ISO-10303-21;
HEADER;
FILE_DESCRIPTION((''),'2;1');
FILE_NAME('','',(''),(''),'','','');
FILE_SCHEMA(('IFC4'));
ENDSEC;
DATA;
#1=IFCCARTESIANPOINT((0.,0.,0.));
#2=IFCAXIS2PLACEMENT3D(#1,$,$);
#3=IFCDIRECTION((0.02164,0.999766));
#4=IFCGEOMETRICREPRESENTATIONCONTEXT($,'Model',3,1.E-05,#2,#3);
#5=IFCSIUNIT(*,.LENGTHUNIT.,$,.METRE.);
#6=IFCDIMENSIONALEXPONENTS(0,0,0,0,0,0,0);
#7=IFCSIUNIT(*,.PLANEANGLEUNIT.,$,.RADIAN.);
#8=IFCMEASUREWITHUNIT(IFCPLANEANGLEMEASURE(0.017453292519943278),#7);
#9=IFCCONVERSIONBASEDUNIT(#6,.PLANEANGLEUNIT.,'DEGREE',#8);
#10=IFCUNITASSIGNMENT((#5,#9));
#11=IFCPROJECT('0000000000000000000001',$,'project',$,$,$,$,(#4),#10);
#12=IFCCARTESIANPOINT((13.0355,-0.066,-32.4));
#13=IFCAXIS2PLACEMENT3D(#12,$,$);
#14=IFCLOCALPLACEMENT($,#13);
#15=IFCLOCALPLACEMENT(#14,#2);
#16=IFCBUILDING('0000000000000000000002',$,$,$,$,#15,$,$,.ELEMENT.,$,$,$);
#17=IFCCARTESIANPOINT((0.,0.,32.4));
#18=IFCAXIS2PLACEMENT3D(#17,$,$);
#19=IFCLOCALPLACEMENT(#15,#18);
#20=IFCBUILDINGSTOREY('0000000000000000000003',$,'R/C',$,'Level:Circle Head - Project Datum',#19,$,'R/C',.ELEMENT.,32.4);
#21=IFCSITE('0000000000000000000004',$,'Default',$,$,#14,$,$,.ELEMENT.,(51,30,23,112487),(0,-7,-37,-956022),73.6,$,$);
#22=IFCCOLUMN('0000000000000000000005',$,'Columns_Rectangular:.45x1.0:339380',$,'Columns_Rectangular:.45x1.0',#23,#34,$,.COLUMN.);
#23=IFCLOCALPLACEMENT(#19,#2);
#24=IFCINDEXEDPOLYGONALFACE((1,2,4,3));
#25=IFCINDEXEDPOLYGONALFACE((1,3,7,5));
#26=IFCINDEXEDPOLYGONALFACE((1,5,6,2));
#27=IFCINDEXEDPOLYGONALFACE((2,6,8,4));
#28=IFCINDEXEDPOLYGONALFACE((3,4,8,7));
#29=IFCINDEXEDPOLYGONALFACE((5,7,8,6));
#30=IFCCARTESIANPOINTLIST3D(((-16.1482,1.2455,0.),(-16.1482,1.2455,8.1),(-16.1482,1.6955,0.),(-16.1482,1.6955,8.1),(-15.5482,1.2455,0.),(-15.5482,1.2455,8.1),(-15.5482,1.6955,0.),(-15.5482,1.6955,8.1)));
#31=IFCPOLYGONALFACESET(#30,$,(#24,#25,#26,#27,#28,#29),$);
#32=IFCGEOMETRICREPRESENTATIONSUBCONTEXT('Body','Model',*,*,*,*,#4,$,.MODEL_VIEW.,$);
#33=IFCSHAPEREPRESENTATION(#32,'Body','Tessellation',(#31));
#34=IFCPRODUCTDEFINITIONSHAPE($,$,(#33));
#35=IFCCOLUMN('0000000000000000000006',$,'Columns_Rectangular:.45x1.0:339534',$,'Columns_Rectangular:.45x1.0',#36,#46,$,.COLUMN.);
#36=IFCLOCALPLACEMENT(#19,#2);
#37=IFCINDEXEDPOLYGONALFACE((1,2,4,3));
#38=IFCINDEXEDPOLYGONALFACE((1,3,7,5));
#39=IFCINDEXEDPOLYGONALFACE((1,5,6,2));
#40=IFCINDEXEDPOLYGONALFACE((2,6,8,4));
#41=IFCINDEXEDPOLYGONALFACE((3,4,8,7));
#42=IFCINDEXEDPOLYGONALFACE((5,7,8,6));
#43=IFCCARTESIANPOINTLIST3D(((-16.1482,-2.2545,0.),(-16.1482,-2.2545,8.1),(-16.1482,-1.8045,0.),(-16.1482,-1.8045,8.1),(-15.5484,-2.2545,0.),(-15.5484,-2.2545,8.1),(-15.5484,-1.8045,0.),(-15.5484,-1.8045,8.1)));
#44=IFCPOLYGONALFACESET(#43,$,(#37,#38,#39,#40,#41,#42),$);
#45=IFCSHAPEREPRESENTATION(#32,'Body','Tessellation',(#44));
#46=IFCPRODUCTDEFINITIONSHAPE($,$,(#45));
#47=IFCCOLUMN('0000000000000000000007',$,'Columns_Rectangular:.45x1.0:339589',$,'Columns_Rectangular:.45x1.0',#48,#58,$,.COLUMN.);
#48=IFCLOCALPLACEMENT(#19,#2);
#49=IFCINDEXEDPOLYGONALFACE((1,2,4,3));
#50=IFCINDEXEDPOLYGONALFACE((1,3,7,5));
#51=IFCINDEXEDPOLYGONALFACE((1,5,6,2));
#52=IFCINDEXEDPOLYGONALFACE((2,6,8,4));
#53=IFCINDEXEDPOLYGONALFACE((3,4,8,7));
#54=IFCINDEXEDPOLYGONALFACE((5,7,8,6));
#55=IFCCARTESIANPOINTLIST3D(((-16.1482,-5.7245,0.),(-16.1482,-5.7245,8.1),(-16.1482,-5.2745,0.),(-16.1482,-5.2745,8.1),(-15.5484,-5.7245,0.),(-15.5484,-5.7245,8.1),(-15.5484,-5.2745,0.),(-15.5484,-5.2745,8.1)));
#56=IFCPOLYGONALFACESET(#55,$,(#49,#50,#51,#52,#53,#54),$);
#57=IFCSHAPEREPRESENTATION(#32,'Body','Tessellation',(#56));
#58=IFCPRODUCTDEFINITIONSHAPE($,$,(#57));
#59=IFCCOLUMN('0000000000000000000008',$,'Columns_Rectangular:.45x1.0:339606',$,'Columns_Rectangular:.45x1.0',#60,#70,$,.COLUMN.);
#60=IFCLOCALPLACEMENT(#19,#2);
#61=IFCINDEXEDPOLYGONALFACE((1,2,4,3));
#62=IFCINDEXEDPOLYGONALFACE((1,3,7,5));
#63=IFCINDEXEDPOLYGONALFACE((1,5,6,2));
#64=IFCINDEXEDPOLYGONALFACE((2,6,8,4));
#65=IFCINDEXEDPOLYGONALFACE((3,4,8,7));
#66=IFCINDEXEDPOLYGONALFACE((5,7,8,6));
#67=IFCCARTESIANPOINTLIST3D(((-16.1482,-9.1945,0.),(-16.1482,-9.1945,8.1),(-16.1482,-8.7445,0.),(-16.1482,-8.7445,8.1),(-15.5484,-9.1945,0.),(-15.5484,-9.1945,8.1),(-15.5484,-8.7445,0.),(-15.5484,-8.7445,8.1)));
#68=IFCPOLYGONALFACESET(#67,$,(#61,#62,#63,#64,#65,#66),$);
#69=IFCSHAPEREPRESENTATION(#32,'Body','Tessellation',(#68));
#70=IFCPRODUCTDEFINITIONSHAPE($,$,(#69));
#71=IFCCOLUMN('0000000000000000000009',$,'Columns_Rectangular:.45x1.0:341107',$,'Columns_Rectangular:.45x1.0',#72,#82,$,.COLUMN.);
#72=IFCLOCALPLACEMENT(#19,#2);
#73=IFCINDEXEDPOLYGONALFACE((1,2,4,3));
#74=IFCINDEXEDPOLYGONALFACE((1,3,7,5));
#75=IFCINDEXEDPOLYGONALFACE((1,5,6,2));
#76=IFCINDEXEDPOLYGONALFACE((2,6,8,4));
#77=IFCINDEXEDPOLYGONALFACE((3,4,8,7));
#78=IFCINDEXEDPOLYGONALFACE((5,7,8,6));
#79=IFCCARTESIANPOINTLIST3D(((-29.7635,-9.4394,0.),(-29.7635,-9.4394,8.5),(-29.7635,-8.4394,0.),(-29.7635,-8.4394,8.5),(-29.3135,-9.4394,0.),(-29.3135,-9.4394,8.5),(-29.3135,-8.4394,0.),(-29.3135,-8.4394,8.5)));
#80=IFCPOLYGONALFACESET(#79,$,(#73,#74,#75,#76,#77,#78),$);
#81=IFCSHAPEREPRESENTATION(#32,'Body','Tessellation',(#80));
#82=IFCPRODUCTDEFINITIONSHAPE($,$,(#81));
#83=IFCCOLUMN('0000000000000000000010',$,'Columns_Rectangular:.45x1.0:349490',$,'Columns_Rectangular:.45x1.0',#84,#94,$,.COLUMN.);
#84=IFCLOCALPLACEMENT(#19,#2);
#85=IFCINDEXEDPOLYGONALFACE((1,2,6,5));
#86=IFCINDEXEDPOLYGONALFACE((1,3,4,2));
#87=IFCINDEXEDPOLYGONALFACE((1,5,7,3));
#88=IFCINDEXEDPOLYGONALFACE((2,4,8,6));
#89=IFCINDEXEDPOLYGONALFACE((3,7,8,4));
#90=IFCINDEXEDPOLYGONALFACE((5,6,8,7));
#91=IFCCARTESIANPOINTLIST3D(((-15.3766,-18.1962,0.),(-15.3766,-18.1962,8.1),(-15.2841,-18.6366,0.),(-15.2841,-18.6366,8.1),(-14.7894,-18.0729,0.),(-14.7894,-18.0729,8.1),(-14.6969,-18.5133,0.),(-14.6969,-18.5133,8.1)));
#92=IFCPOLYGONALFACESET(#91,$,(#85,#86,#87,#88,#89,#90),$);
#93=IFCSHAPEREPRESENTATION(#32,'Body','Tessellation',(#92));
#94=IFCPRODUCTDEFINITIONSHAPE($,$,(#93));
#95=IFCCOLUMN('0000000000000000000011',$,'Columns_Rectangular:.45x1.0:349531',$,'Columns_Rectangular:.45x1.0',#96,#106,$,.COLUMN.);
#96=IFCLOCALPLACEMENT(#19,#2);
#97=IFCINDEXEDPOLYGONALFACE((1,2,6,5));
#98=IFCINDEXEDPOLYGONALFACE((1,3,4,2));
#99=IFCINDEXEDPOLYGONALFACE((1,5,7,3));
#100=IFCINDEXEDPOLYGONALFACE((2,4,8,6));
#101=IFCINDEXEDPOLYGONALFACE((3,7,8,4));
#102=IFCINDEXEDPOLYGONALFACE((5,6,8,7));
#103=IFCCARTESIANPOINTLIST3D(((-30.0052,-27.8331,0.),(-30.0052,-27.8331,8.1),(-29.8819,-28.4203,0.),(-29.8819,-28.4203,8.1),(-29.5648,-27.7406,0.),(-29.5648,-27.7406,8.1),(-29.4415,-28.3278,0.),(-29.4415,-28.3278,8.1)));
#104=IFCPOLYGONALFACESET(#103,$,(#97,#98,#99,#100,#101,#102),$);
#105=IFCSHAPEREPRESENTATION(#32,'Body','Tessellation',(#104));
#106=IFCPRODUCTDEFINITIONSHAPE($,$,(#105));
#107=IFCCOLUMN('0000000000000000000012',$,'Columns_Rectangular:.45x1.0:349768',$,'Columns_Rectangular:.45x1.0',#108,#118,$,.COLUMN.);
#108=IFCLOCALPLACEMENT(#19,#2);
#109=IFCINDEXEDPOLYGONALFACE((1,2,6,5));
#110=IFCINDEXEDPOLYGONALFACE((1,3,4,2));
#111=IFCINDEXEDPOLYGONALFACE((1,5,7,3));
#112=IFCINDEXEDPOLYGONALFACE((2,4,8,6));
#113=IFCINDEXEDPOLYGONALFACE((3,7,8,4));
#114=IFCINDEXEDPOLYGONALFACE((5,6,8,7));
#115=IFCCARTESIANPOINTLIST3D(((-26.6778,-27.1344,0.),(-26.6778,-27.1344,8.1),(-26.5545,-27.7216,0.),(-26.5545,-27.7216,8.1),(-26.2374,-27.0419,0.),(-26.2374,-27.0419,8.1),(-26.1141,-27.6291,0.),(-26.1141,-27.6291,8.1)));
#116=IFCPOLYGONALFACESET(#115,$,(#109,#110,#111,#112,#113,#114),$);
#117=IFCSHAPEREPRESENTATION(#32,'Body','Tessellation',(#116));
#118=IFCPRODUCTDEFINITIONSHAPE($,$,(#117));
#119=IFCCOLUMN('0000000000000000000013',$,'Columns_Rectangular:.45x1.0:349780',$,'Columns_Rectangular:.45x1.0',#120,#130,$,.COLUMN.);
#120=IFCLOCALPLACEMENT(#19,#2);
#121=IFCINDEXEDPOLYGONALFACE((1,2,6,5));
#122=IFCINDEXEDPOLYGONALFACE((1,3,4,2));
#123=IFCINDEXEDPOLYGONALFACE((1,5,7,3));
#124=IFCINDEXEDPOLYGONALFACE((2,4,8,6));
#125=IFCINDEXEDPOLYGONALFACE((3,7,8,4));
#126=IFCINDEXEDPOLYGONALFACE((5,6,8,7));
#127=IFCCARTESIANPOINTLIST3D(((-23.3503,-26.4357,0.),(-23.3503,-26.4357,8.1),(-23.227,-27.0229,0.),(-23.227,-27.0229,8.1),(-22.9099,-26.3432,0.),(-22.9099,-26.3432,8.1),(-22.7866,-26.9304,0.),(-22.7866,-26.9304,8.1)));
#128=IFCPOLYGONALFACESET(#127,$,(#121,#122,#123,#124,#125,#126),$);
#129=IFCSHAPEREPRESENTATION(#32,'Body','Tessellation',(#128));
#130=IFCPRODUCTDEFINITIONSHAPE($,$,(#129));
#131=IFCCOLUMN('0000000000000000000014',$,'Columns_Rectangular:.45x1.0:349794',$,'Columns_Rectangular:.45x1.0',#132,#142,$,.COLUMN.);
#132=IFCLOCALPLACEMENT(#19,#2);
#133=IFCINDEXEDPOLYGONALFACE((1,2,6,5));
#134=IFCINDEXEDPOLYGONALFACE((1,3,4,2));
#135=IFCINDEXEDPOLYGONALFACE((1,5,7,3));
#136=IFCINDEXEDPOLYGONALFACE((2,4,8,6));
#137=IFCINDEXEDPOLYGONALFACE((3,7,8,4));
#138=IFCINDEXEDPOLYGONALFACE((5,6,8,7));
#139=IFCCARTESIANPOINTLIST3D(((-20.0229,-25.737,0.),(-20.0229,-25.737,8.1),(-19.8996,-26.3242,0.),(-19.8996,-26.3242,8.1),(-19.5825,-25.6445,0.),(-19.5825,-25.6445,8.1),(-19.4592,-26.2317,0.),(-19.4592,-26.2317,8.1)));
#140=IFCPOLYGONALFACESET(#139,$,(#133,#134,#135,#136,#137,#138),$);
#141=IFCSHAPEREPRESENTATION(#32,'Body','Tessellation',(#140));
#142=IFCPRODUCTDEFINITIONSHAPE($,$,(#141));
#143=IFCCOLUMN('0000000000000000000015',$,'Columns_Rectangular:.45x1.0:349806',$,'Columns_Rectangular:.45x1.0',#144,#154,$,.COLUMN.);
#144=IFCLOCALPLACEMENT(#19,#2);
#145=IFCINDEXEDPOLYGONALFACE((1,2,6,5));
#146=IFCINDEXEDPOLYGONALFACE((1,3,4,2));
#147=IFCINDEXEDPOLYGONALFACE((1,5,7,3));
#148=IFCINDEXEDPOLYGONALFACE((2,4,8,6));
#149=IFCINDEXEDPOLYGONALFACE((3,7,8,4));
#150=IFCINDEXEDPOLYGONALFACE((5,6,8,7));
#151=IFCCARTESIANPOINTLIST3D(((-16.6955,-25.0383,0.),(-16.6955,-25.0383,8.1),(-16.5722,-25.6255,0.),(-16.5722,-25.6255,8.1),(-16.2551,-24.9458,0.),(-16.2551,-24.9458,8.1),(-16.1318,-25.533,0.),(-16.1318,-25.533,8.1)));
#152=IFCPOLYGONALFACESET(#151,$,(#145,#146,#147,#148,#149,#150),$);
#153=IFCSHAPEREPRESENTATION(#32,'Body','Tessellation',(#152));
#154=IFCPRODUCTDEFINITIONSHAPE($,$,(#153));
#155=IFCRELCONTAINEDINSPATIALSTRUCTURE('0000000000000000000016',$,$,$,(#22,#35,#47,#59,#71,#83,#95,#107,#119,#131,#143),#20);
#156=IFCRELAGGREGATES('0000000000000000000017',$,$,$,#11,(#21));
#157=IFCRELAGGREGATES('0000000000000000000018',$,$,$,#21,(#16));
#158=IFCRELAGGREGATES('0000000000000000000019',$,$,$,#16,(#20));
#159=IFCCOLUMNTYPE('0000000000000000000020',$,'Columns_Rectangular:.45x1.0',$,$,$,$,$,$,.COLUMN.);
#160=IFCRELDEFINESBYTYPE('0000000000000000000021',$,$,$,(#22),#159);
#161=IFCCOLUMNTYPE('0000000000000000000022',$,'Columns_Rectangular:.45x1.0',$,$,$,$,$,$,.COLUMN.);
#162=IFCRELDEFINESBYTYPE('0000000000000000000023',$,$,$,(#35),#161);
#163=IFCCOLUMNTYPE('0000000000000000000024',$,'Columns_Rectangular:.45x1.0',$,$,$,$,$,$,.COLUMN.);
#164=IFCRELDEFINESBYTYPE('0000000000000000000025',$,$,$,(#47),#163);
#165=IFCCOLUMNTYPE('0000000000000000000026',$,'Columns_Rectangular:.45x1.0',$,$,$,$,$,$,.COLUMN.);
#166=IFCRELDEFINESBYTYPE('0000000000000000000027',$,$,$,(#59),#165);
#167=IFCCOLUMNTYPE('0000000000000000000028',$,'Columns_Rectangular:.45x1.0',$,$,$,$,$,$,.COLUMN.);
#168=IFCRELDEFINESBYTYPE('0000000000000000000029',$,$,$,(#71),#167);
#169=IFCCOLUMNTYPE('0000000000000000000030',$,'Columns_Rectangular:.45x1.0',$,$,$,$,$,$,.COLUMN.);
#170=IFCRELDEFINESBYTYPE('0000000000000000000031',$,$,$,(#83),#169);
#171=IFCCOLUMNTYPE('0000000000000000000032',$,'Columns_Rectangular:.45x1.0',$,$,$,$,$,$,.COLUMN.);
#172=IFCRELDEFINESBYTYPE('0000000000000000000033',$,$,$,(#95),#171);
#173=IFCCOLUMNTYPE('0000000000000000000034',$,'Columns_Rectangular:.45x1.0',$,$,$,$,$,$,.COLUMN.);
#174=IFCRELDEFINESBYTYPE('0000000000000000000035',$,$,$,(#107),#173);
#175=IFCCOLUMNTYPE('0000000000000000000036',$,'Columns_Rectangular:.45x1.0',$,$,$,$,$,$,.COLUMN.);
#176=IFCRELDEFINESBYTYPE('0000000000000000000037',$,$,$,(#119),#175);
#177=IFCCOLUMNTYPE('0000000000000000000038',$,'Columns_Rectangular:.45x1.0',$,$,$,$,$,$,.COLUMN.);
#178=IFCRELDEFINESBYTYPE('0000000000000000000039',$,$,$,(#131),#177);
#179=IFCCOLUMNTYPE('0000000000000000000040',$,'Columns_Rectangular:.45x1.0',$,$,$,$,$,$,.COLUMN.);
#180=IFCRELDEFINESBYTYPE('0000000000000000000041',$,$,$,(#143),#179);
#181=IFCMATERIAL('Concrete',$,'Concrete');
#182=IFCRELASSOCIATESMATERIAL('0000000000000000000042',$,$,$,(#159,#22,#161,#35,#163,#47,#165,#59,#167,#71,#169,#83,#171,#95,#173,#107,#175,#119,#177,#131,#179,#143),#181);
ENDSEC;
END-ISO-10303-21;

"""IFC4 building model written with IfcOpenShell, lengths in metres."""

from ifc_helpers import new_model, entity, si_unit, converted_unit, direction, frame, origin, place, context, subcontext, project, spatial, indexed_curve, outline, extrude, source, transform, mapped, material, type_object, type_shapes, element, save


model = new_model("IFC4")

# Units and contexts
model_context = context("Model", 3, precision=1e-05, world=origin(), true_north=direction((0.02164, 0.999766)))
body_context = subcontext(model_context, "Body", "Model", "MODEL_VIEW")
ifc_project = project(units=[si_unit("LENGTHUNIT", "METRE"), converted_unit("PLANEANGLEUNIT", "DEGREE", entity("IfcPlaneAngleMeasure", 0.017453292519943278), si_unit("PLANEANGLEUNIT", "RADIAN"), dimensions=[0, 0, 0, 0, 0, 0, 0])], contexts=[model_context])

# Site, building, storey
site_placement = place(None, frame((13.0355, -0.066, -32.4)))
site = spatial("IfcSite", under=ifc_project, at=site_placement, Name="Default", CompositionType="ELEMENT", RefLatitude=(51, 30, 23, 112487), RefLongitude=(0, -7, -37, -956022), RefElevation=73.6)
building_placement = place(site_placement, origin())
building = spatial("IfcBuilding", under=site, at=building_placement, CompositionType="ELEMENT")
storey_placement = place(building_placement, frame((0.0, 0.0, 32.4)))
storey = spatial("IfcBuildingStorey", under=building, at=storey_placement, Name="R/C", ObjectType="Level:Circle Head - Project Datum", LongName="R/C", CompositionType="ELEMENT", Elevation=32.4)

# Columns
ifc_material = material(Name="Concrete", Category="Concrete")
column_type_1 = type_object("IfcColumnType", Name="Columns_Rectangular:.45x1.0", PredefinedType="COLUMN", material=ifc_material)
shared_shape_1 = source(origin(), body_context, "Body", "SweptSolid", [
    extrude(outline(indexed_curve([(-0.3, -0.225), (0.3, -0.225), (0.3, 0.225), (-0.3, 0.225), (-0.3, -0.225)], self_intersect=False)), frame((-15.8482, 1.4705, 32.4), z_axis=(0.0, 0.0, 1.0), x_axis=(-1.0, 0.0, 0.0)), (0.0, 0.0, 1.0), 8.1),
])
type_shapes(column_type_1, [shared_shape_1])
column_1_placement = place(storey_placement, frame((0.0, 0.0, -32.4)))
element("IfcColumn", 1, at=column_1_placement, inside=storey, type_object=column_type_1, material=ifc_material, Name="Columns_Rectangular:.45x1.0:339380", ObjectType="Columns_Rectangular:.45x1.0", PredefinedType="COLUMN", context=body_context, shape_type="MappedRepresentation", body=[
    mapped(shared_shape_1, transform((0.0, 0.0, 0.0), scale=1.0)),
])
column_type_2 = type_object("IfcColumnType", Name="Columns_Rectangular:.45x1.0", PredefinedType="COLUMN", material=ifc_material)
shared_shape_2 = source(origin(), body_context, "Body", "SweptSolid", [
    extrude(outline(indexed_curve([(-0.2999, -0.225), (0.2999, -0.225), (0.2999, 0.225), (-0.2999, 0.225), (-0.2999, -0.225)], self_intersect=False)), frame((-15.8483, -2.0295, 32.4), z_axis=(0.0, 0.0, 1.0), x_axis=(-1.0, 0.0, 0.0)), (0.0, 0.0, 1.0), 8.1),
])
type_shapes(column_type_2, [shared_shape_2])
column_2_placement = place(storey_placement, frame((0.0, 0.0, -32.4)))
element("IfcColumn", 2, at=column_2_placement, inside=storey, type_object=column_type_2, material=ifc_material, Name="Columns_Rectangular:.45x1.0:339534", ObjectType="Columns_Rectangular:.45x1.0", PredefinedType="COLUMN", context=body_context, shape_type="MappedRepresentation", body=[
    mapped(shared_shape_2, transform((0.0, 0.0, 0.0), scale=1.0)),
])
column_type_3 = type_object("IfcColumnType", Name="Columns_Rectangular:.45x1.0", PredefinedType="COLUMN", material=ifc_material)
shared_shape_3 = source(origin(), body_context, "Body", "SweptSolid", [
    extrude(outline(indexed_curve([(-0.2999, -0.225), (0.2999, -0.225), (0.2999, 0.225), (-0.2999, 0.225), (-0.2999, -0.225)], self_intersect=False)), frame((-15.8483, -5.4995, 32.4), z_axis=(0.0, 0.0, 1.0), x_axis=(-1.0, 0.0, 0.0)), (0.0, 0.0, 1.0), 8.1),
])
type_shapes(column_type_3, [shared_shape_3])
column_3_placement = place(storey_placement, frame((0.0, 0.0, -32.4)))
element("IfcColumn", 3, at=column_3_placement, inside=storey, type_object=column_type_3, material=ifc_material, Name="Columns_Rectangular:.45x1.0:339589", ObjectType="Columns_Rectangular:.45x1.0", PredefinedType="COLUMN", context=body_context, shape_type="MappedRepresentation", body=[
    mapped(shared_shape_3, transform((0.0, 0.0, 0.0), scale=1.0)),
])
column_type_4 = type_object("IfcColumnType", Name="Columns_Rectangular:.45x1.0", PredefinedType="COLUMN", material=ifc_material)
shared_shape_4 = source(origin(), body_context, "Body", "SweptSolid", [
    extrude(outline(indexed_curve([(-0.2999, -0.225), (0.2999, -0.225), (0.2999, 0.225), (-0.2999, 0.225), (-0.2999, -0.225)], self_intersect=False)), frame((-15.8483, -8.9695, 32.4), z_axis=(0.0, 0.0, 1.0), x_axis=(-1.0, 0.0, 0.0)), (0.0, 0.0, 1.0), 8.1),
])
type_shapes(column_type_4, [shared_shape_4])
column_4_placement = place(storey_placement, frame((0.0, 0.0, -32.4)))
element("IfcColumn", 4, at=column_4_placement, inside=storey, type_object=column_type_4, material=ifc_material, Name="Columns_Rectangular:.45x1.0:339606", ObjectType="Columns_Rectangular:.45x1.0", PredefinedType="COLUMN", context=body_context, shape_type="MappedRepresentation", body=[
    mapped(shared_shape_4, transform((0.0, 0.0, 0.0), scale=1.0)),
])
column_type_5 = type_object("IfcColumnType", Name="Columns_Rectangular:.45x1.0", PredefinedType="COLUMN", material=ifc_material)
shared_shape_5 = source(origin(), body_context, "Body", "SweptSolid", [
    extrude(outline(indexed_curve([(-0.5, -0.225), (0.5, -0.225), (0.5, 0.225), (-0.5, 0.225), (-0.5, -0.225)], self_intersect=False)), frame((-29.5385, -8.9394, 32.4), z_axis=(0.0, 0.0, 1.0), x_axis=(0.0, 1.0, 0.0)), (0.0, 0.0, 1.0), 8.5),
])
type_shapes(column_type_5, [shared_shape_5])
column_5_placement = place(storey_placement, frame((0.0, 0.0, -32.4)))
element("IfcColumn", 5, at=column_5_placement, inside=storey, type_object=column_type_5, material=ifc_material, Name="Columns_Rectangular:.45x1.0:341107", ObjectType="Columns_Rectangular:.45x1.0", PredefinedType="COLUMN", context=body_context, shape_type="MappedRepresentation", body=[
    mapped(shared_shape_5, transform((0.0, 0.0, 0.0), scale=1.0)),
])
column_type_6 = type_object("IfcColumnType", Name="Columns_Rectangular:.45x1.0", PredefinedType="COLUMN", material=ifc_material)
shared_shape_6 = source(origin(), body_context, "Body", "SweptSolid", [
    extrude(outline(indexed_curve([(-0.3, -0.225), (0.3, -0.225), (0.3, 0.225), (-0.3, 0.225), (-0.3, -0.225)], self_intersect=False)), frame((-15.0367, -18.3548, 32.4), z_axis=(0.0, 0.0, 1.0), x_axis=(0.978657, 0.2055, 0.0)), (0.0, 0.0, 1.0), 8.1),
])
type_shapes(column_type_6, [shared_shape_6])
column_6_placement = place(storey_placement, frame((0.0, 0.0, -32.4)))
element("IfcColumn", 6, at=column_6_placement, inside=storey, type_object=column_type_6, material=ifc_material, Name="Columns_Rectangular:.45x1.0:349490", ObjectType="Columns_Rectangular:.45x1.0", PredefinedType="COLUMN", context=body_context, shape_type="MappedRepresentation", body=[
    mapped(shared_shape_6, transform((0.0, 0.0, 0.0), scale=1.0)),
])
column_type_7 = type_object("IfcColumnType", Name="Columns_Rectangular:.45x1.0", PredefinedType="COLUMN", material=ifc_material)
shared_shape_7 = source(origin(), body_context, "Body", "SweptSolid", [
    extrude(outline(indexed_curve([(-0.3, -0.225), (0.3, -0.225), (0.3, 0.225), (-0.3, 0.225), (-0.3, -0.225)], self_intersect=False)), frame((-29.7234, -28.0804, 32.4), z_axis=(0.0, 0.0, 1.0), x_axis=(0.2055, -0.978657, 0.0)), (0.0, 0.0, 1.0), 8.1),
])
type_shapes(column_type_7, [shared_shape_7])
column_7_placement = place(storey_placement, frame((0.0, 0.0, -32.4)))
element("IfcColumn", 7, at=column_7_placement, inside=storey, type_object=column_type_7, material=ifc_material, Name="Columns_Rectangular:.45x1.0:349531", ObjectType="Columns_Rectangular:.45x1.0", PredefinedType="COLUMN", context=body_context, shape_type="MappedRepresentation", body=[
    mapped(shared_shape_7, transform((0.0, 0.0, 0.0), scale=1.0)),
])
column_type_8 = type_object("IfcColumnType", Name="Columns_Rectangular:.45x1.0", PredefinedType="COLUMN", material=ifc_material)
shared_shape_8 = source(origin(), body_context, "Body", "SweptSolid", [
    extrude(outline(indexed_curve([(-0.3, -0.225), (0.3, -0.225), (0.3, 0.225), (-0.3, 0.225), (-0.3, -0.225)], self_intersect=False)), frame((-26.3959, -27.3817, 32.4), z_axis=(0.0, 0.0, 1.0), x_axis=(0.2055, -0.978657, 0.0)), (0.0, 0.0, 1.0), 8.1),
])
type_shapes(column_type_8, [shared_shape_8])
column_8_placement = place(storey_placement, frame((0.0, 0.0, -32.4)))
element("IfcColumn", 8, at=column_8_placement, inside=storey, type_object=column_type_8, material=ifc_material, Name="Columns_Rectangular:.45x1.0:349768", ObjectType="Columns_Rectangular:.45x1.0", PredefinedType="COLUMN", context=body_context, shape_type="MappedRepresentation", body=[
    mapped(shared_shape_8, transform((0.0, 0.0, 0.0), scale=1.0)),
])
column_type_9 = type_object("IfcColumnType", Name="Columns_Rectangular:.45x1.0", PredefinedType="COLUMN", material=ifc_material)
shared_shape_9 = source(origin(), body_context, "Body", "SweptSolid", [
    extrude(outline(indexed_curve([(-0.3, -0.225), (0.3, -0.225), (0.3, 0.225), (-0.3, 0.225), (-0.3, -0.225)], self_intersect=False)), frame((-23.0685, -26.6831, 32.4), z_axis=(0.0, 0.0, 1.0), x_axis=(0.2055, -0.978657, 0.0)), (0.0, 0.0, 1.0), 8.1),
])
type_shapes(column_type_9, [shared_shape_9])
column_9_placement = place(storey_placement, frame((0.0, 0.0, -32.4)))
element("IfcColumn", 9, at=column_9_placement, inside=storey, type_object=column_type_9, material=ifc_material, Name="Columns_Rectangular:.45x1.0:349780", ObjectType="Columns_Rectangular:.45x1.0", PredefinedType="COLUMN", context=body_context, shape_type="MappedRepresentation", body=[
    mapped(shared_shape_9, transform((0.0, 0.0, 0.0), scale=1.0)),
])
column_type_10 = type_object("IfcColumnType", Name="Columns_Rectangular:.45x1.0", PredefinedType="COLUMN", material=ifc_material)
shared_shape_10 = source(origin(), body_context, "Body", "SweptSolid", [
    extrude(outline(indexed_curve([(-0.3, -0.225), (0.3, -0.225), (0.3, 0.225), (-0.3, 0.225), (-0.3, -0.225)], self_intersect=False)), frame((-19.741, -25.9844, 32.4), z_axis=(0.0, 0.0, 1.0), x_axis=(0.2055, -0.978657, 0.0)), (0.0, 0.0, 1.0), 8.1),
])
type_shapes(column_type_10, [shared_shape_10])
column_10_placement = place(storey_placement, frame((0.0, 0.0, -32.4)))
element("IfcColumn", 10, at=column_10_placement, inside=storey, type_object=column_type_10, material=ifc_material, Name="Columns_Rectangular:.45x1.0:349794", ObjectType="Columns_Rectangular:.45x1.0", PredefinedType="COLUMN", context=body_context, shape_type="MappedRepresentation", body=[
    mapped(shared_shape_10, transform((0.0, 0.0, 0.0), scale=1.0)),
])
column_type_11 = type_object("IfcColumnType", Name="Columns_Rectangular:.45x1.0", PredefinedType="COLUMN", material=ifc_material)
shared_shape_11 = source(origin(), body_context, "Body", "SweptSolid", [
    extrude(outline(indexed_curve([(-0.3, -0.225), (0.3, -0.225), (0.3, 0.225), (-0.3, 0.225), (-0.3, -0.225)], self_intersect=False)), frame((-16.4136, -25.2857, 32.4), z_axis=(0.0, 0.0, 1.0), x_axis=(0.2055, -0.978657, 0.0)), (0.0, 0.0, 1.0), 8.1),
])
type_shapes(column_type_11, [shared_shape_11])
column_11_placement = place(storey_placement, frame((0.0, 0.0, -32.4)))
element("IfcColumn", 11, at=column_11_placement, inside=storey, type_object=column_type_11, material=ifc_material, Name="Columns_Rectangular:.45x1.0:349806", ObjectType="Columns_Rectangular:.45x1.0", PredefinedType="COLUMN", context=body_context, shape_type="MappedRepresentation", body=[
    mapped(shared_shape_11, transform((0.0, 0.0, 0.0), scale=1.0)),
])

save(model, "model.ifc")
